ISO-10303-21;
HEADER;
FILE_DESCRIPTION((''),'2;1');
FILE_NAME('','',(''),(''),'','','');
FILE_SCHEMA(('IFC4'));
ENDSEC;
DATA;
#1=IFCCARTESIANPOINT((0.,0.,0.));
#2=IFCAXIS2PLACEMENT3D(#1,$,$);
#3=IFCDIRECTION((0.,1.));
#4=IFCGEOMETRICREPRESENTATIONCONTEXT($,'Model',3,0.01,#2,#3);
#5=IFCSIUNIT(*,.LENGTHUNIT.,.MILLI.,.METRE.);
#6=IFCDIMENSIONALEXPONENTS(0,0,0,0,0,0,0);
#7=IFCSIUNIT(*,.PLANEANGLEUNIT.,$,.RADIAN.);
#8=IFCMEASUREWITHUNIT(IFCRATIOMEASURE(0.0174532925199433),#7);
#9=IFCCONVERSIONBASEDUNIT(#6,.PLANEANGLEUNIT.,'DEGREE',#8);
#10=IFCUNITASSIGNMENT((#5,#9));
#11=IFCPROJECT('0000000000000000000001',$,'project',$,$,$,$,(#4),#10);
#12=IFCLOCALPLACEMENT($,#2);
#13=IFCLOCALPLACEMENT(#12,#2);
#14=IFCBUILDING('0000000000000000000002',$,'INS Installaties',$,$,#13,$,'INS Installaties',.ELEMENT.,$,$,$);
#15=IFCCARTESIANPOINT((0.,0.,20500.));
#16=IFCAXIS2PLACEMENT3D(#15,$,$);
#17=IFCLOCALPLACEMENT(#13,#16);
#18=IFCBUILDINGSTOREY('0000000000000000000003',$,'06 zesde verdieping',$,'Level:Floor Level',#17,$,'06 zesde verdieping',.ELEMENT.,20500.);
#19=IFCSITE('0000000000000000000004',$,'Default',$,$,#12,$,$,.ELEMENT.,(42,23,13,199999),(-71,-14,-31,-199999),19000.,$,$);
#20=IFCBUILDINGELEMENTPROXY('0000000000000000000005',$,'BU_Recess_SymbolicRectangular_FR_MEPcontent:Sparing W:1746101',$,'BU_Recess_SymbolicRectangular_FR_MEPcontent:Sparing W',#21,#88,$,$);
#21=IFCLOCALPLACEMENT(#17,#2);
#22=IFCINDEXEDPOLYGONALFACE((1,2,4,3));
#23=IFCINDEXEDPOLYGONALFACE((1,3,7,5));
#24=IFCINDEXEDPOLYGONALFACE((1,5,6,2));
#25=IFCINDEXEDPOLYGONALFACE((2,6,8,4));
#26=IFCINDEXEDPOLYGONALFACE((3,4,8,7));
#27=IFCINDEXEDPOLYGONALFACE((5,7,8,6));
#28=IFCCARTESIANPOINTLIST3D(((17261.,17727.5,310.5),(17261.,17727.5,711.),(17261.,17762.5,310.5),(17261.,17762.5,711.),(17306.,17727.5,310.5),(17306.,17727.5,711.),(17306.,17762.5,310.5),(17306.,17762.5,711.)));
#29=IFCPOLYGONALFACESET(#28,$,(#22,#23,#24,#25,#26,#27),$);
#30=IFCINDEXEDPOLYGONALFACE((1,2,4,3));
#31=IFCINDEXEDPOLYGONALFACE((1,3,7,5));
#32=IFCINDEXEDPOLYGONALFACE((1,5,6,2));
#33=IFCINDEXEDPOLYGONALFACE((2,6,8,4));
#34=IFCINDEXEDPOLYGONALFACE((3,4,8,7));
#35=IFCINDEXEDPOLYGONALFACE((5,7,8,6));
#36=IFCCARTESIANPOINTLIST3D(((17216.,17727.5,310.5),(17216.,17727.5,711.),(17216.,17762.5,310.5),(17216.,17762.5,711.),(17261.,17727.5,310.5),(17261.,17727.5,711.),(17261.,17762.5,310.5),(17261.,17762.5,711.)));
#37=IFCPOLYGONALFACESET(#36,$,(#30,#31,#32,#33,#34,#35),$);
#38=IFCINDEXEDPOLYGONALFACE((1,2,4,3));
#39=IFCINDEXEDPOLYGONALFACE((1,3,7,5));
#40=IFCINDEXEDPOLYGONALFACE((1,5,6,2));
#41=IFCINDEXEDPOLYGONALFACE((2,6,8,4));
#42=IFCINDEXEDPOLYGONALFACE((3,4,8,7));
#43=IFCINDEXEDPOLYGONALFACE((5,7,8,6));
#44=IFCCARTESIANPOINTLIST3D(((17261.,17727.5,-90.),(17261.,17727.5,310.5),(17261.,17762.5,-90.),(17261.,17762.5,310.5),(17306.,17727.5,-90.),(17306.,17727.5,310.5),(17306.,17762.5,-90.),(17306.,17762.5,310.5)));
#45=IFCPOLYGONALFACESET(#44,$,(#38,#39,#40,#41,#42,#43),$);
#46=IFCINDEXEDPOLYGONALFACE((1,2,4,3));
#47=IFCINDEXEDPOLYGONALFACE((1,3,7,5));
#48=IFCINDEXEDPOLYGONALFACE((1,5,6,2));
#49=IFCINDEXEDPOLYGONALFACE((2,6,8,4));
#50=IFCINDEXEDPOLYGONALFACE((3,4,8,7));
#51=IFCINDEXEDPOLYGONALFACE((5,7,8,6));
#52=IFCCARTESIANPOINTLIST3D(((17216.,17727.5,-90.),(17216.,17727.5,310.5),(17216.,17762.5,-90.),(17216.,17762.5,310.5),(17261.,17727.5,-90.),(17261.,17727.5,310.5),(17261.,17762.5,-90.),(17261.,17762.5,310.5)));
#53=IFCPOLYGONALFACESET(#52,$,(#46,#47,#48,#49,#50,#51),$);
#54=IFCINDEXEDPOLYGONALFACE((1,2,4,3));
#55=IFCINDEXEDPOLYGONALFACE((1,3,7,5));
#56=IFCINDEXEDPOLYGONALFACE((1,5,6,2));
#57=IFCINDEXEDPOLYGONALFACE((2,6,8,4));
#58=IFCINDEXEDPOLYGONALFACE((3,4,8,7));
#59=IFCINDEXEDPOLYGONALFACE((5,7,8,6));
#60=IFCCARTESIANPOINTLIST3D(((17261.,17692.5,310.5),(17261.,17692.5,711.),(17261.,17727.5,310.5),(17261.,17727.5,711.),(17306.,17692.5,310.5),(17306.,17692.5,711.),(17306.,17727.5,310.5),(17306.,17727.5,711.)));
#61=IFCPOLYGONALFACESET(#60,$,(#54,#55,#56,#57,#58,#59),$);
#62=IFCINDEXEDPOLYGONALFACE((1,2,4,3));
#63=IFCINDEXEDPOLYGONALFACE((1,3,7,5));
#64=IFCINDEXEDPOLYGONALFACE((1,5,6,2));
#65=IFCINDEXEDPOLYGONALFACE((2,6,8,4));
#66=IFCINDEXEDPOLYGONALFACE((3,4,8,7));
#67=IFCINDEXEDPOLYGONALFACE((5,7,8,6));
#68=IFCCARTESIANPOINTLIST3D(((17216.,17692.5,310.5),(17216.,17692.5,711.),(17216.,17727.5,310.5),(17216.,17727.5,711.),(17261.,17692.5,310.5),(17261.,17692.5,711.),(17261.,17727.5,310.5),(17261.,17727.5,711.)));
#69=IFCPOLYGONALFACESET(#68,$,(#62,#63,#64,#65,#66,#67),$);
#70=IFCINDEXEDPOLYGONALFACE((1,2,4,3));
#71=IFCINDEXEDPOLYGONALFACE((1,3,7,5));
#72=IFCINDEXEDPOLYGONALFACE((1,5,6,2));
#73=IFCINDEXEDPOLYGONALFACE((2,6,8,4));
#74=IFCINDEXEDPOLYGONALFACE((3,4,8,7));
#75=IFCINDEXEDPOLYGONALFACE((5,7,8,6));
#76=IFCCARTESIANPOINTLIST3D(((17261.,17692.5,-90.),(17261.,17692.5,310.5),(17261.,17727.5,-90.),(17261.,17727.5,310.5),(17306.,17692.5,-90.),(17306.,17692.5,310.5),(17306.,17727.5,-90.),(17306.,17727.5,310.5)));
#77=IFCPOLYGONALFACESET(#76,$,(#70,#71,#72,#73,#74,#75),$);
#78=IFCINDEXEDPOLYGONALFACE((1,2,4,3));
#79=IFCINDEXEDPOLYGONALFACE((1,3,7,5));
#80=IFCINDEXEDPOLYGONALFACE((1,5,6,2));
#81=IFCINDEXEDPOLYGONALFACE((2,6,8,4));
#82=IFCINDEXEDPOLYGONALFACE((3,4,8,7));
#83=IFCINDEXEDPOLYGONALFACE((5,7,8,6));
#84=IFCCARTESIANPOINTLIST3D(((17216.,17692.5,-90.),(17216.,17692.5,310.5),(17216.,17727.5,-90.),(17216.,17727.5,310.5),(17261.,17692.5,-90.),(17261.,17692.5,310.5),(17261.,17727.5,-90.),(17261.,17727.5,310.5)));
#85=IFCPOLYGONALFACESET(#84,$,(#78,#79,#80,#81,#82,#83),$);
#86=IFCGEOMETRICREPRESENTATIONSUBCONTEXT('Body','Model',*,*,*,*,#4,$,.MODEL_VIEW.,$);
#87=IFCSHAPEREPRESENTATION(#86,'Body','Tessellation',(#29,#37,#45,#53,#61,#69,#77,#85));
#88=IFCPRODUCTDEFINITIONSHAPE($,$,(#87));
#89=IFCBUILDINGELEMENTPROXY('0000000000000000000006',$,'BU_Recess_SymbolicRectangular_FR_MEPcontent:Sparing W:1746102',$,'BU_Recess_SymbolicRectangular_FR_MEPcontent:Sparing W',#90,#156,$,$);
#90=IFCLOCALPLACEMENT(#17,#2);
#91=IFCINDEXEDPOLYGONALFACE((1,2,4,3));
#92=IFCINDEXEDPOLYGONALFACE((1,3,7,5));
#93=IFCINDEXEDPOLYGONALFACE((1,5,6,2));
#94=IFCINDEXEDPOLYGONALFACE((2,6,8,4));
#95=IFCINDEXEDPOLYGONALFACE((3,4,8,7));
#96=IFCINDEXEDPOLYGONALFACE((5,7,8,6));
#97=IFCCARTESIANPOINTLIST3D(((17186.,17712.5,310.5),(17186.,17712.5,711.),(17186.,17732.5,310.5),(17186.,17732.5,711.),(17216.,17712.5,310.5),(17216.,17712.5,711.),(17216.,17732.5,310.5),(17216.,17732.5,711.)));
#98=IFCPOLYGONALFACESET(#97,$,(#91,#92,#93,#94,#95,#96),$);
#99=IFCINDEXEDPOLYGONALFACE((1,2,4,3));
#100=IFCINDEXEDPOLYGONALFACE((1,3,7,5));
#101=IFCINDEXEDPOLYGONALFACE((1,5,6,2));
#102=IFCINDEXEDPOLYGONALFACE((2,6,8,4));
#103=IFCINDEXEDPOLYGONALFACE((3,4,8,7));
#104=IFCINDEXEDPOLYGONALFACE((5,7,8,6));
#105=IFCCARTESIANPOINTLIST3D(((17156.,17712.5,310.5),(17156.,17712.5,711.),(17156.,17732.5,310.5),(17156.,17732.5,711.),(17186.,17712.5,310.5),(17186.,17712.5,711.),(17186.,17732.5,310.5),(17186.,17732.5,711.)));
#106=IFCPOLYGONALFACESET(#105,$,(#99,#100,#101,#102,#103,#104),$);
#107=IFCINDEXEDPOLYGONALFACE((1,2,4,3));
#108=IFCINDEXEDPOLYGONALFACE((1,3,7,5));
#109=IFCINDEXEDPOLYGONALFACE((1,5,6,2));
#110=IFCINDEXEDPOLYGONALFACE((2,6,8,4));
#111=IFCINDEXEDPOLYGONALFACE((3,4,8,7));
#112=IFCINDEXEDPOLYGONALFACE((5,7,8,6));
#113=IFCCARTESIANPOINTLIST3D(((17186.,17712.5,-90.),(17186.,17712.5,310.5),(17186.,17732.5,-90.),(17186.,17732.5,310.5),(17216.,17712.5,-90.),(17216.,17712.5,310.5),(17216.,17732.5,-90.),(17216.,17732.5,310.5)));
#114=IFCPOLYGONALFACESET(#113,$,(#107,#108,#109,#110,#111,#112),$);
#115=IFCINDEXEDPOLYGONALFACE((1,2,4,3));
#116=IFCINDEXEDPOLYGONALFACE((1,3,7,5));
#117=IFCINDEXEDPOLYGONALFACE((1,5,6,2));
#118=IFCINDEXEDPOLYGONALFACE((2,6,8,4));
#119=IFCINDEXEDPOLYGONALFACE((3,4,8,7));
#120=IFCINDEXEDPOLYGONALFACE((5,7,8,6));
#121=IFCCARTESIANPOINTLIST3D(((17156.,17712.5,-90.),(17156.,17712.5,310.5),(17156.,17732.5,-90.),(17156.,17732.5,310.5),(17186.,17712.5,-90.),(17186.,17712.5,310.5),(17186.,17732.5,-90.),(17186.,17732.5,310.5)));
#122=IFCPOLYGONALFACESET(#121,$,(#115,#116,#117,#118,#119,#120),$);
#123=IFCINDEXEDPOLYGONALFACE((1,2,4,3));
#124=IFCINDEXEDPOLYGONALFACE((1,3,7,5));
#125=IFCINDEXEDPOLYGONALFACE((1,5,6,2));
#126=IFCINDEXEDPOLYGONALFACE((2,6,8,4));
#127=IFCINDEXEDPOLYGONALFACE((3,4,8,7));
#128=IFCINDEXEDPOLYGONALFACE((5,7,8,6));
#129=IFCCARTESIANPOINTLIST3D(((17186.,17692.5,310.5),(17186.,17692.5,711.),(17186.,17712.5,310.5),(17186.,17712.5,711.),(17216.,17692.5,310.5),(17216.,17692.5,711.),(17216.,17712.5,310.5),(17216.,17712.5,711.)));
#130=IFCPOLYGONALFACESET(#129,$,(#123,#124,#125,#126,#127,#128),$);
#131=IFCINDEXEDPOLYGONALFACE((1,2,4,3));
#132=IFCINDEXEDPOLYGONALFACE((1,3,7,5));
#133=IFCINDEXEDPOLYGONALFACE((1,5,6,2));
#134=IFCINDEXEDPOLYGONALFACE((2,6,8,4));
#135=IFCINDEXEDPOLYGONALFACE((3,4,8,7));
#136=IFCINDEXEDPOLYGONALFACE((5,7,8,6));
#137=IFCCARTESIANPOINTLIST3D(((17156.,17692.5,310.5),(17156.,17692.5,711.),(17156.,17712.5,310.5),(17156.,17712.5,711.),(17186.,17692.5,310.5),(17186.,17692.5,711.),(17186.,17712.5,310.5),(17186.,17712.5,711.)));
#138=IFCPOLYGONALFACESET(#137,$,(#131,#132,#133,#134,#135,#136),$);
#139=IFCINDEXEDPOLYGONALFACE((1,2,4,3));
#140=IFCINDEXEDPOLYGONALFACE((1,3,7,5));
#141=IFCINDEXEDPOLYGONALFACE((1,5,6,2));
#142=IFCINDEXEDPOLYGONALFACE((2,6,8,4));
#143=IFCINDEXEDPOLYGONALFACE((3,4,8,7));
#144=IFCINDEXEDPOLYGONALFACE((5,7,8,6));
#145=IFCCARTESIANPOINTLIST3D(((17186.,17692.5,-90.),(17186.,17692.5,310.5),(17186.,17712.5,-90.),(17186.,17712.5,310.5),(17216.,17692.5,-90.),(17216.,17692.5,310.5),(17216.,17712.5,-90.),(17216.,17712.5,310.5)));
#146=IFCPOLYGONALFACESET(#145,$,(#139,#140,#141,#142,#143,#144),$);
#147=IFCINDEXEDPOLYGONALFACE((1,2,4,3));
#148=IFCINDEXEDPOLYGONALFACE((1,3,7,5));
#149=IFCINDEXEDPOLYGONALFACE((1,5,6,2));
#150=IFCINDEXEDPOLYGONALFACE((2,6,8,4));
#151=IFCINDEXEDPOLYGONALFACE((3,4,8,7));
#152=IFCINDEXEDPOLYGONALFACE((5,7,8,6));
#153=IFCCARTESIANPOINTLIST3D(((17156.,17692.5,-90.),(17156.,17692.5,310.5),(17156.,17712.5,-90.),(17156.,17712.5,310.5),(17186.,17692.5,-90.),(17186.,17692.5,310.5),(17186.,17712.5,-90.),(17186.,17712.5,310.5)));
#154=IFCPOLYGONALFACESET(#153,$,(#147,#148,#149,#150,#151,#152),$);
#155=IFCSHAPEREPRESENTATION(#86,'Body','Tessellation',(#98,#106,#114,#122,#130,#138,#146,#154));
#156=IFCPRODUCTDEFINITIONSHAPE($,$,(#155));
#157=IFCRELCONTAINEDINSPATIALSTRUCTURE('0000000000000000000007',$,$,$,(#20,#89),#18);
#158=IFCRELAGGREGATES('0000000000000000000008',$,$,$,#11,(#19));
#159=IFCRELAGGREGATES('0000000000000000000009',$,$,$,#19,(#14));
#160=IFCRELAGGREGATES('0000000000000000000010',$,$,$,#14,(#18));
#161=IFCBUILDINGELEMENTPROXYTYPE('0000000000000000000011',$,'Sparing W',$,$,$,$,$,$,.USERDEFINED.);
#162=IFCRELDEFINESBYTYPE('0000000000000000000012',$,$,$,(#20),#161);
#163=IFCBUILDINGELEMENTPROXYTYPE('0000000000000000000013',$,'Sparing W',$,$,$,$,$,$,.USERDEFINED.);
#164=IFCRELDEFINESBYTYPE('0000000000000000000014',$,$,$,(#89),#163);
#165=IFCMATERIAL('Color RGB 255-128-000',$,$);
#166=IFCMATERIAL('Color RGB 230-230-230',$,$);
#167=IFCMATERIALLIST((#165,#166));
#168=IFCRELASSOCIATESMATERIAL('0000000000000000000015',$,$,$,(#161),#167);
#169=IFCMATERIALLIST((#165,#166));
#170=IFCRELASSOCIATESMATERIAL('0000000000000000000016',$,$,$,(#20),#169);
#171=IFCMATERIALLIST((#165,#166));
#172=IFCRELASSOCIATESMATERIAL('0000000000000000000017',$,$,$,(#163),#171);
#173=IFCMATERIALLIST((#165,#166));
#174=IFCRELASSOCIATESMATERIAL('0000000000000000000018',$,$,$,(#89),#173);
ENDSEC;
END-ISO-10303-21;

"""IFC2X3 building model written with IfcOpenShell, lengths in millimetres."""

from ifc_helpers import new_model, entity, si_unit, converted_unit, direction, frame, frame_2d, origin, origin_2d_with_axis, place, context, subcontext, project, spatial, rectangle, extrude, source, transform, mapped, material, material_list, type_object, type_shapes, element, save


model = new_model("IFC2X3")

# Units and contexts
model_context = context("Model", 3, precision=0.01, world=origin(), true_north=direction((0.0, 1.0)))
body_context = subcontext(model_context, "Body", "Model", "MODEL_VIEW")
ifc_project = project(units=[si_unit("LENGTHUNIT", "METRE", prefix="MILLI"), converted_unit("PLANEANGLEUNIT", "DEGREE", entity("IfcRatioMeasure", 0.0174532925199433), si_unit("PLANEANGLEUNIT", "RADIAN"), dimensions=[0, 0, 0, 0, 0, 0, 0])], contexts=[model_context])

# Site, building, storey
site_placement = place(None, origin())
site = spatial("IfcSite", under=ifc_project, at=site_placement, Name="Default", CompositionType="ELEMENT", RefLatitude=(42, 23, 13, 199999), RefLongitude=(-71, -14, -31, -199999), RefElevation=19000.0)
building_placement = place(site_placement, origin())
building = spatial("IfcBuilding", under=site, at=building_placement, Name="INS Installaties", LongName="INS Installaties", CompositionType="ELEMENT")
storey_placement = place(building_placement, frame((0.0, 0.0, 20500.0)))
storey = spatial("IfcBuildingStorey", under=building, at=storey_placement, Name="06 zesde verdieping", ObjectType="Level:Floor Level", LongName="06 zesde verdieping", CompositionType="ELEMENT", Elevation=20500.0)

# Building element proxies
ifc_material_1 = material(Name="Color RGB 255-128-000")
ifc_material_2 = material(Name="Color RGB 230-230-230")
ifc_material_list_1 = material_list([ifc_material_1, ifc_material_2])
ifc_material_list_2 = material_list([ifc_material_1, ifc_material_2])
building_element_proxy_type_1 = type_object("IfcBuildingElementProxyType", Name="Sparing W", PredefinedType="USERDEFINED", material=ifc_material_list_2)
shared_shape_1 = source(origin(), body_context, "Body", "SweptSolid", [
    extrude(rectangle(XDim=45.0, YDim=35.0, at=frame_2d((0.0, 0.0), x_axis=(1.0, 0.0))), frame((22.5, 49.5, 0.0)), (0.0, 0.0, 1.0), 400.5),
    extrude(rectangle(XDim=45.0, YDim=35.0, at=frame_2d((0.0, 0.0), x_axis=(1.0, 0.0))), frame((-22.5, 49.5, 0.0)), (0.0, 0.0, 1.0), 400.5),
    extrude(rectangle(XDim=45.0, YDim=35.0, at=frame_2d((0.0, 0.0), x_axis=(1.0, 0.0))), frame((22.5, 49.5, -400.5)), (0.0, 0.0, 1.0), 400.5),
    extrude(rectangle(XDim=45.0, YDim=35.0, at=frame_2d((0.0, 0.0), x_axis=(1.0, 0.0))), frame((-22.5, 49.5, -400.5)), (0.0, 0.0, 1.0), 400.5),
    extrude(rectangle(XDim=45.0, YDim=35.0, at=origin_2d_with_axis()), frame((22.5, 14.5, 0.0)), (0.0, 0.0, 1.0), 400.5),
    extrude(rectangle(XDim=45.0, YDim=35.0, at=frame_2d((0.0, 0.0), x_axis=(1.0, 0.0))), frame((-22.5, 14.5, 0.0)), (0.0, 0.0, 1.0), 400.5),
    extrude(rectangle(XDim=45.0, YDim=35.0, at=frame_2d((0.0, 0.0), x_axis=(1.0, 0.0))), frame((22.5, 14.5, -400.5)), (0.0, 0.0, 1.0), 400.5),
    extrude(rectangle(XDim=45.0, YDim=35.0, at=origin_2d_with_axis()), frame((-22.5, 14.5, -400.5)), (0.0, 0.0, 1.0), 400.5),
])
type_shapes(building_element_proxy_type_1, [shared_shape_1])
proxy_1_placement = place(storey_placement, frame((17261.0, 17695.5, 310.5)))
element("IfcBuildingElementProxy", 1, at=proxy_1_placement, inside=storey, type_object=building_element_proxy_type_1, material=ifc_material_list_1, Name="BU_Recess_SymbolicRectangular_FR_MEPcontent:Sparing W:1746101", ObjectType="BU_Recess_SymbolicRectangular_FR_MEPcontent:Sparing W", context=body_context, shape_type="MappedRepresentation", body=[
    mapped(shared_shape_1, transform((0.0, 0.0, 0.0), scale=1.0)),
])
ifc_material_list_3 = material_list([ifc_material_1, ifc_material_2])
ifc_material_list_4 = material_list([ifc_material_1, ifc_material_2])
building_element_proxy_type_2 = type_object("IfcBuildingElementProxyType", Name="Sparing W", PredefinedType="USERDEFINED", material=ifc_material_list_4)
shared_shape_2 = source(origin(), body_context, "Body", "SweptSolid", [
    extrude(rectangle(XDim=30.0, YDim=20.0, at=frame_2d((0.0, 0.0), x_axis=(1.0, 0.0))), frame((15.0, 27.0, 0.0)), (0.0, 0.0, 1.0), 400.5),
    extrude(rectangle(XDim=30.0, YDim=20.0, at=frame_2d((0.0, 0.0), x_axis=(1.0, 0.0))), frame((-15.0, 27.0, 0.0)), (0.0, 0.0, 1.0), 400.5),
    extrude(rectangle(XDim=30.0, YDim=20.0, at=frame_2d((0.0, 0.0), x_axis=(1.0, 0.0))), frame((15.0, 27.0, -400.5)), (0.0, 0.0, 1.0), 400.5),
    extrude(rectangle(XDim=30.0, YDim=20.0, at=origin_2d_with_axis()), frame((-15.0, 27.0, -400.5)), (0.0, 0.0, 1.0), 400.5),
    extrude(rectangle(XDim=30.0, YDim=20.0, at=frame_2d((0.0, 0.0), x_axis=(1.0, 0.0))), frame((15.0, 7.0, 0.0)), (0.0, 0.0, 1.0), 400.5),
    extrude(rectangle(XDim=30.0, YDim=20.0, at=origin_2d_with_axis()), frame((-15.0, 7.0, 0.0)), (0.0, 0.0, 1.0), 400.5),
    extrude(rectangle(XDim=30.0, YDim=20.0, at=frame_2d((0.0, 0.0), x_axis=(1.0, 0.0))), frame((15.0, 7.0, -400.5)), (0.0, 0.0, 1.0), 400.5),
    extrude(rectangle(XDim=30.0, YDim=20.0, at=origin_2d_with_axis()), frame((-15.0, 7.0, -400.5)), (0.0, 0.0, 1.0), 400.5),
])
type_shapes(building_element_proxy_type_2, [shared_shape_2])
proxy_2_placement = place(storey_placement, frame((17186.0, 17695.5, 310.5)))
element("IfcBuildingElementProxy", 2, at=proxy_2_placement, inside=storey, type_object=building_element_proxy_type_2, material=ifc_material_list_3, Name="BU_Recess_SymbolicRectangular_FR_MEPcontent:Sparing W:1746102", ObjectType="BU_Recess_SymbolicRectangular_FR_MEPcontent:Sparing W", context=body_context, shape_type="MappedRepresentation", body=[
    mapped(shared_shape_2, transform((0.0, 0.0, 0.0), scale=1.0)),
])

save(model, "model.ifc")
